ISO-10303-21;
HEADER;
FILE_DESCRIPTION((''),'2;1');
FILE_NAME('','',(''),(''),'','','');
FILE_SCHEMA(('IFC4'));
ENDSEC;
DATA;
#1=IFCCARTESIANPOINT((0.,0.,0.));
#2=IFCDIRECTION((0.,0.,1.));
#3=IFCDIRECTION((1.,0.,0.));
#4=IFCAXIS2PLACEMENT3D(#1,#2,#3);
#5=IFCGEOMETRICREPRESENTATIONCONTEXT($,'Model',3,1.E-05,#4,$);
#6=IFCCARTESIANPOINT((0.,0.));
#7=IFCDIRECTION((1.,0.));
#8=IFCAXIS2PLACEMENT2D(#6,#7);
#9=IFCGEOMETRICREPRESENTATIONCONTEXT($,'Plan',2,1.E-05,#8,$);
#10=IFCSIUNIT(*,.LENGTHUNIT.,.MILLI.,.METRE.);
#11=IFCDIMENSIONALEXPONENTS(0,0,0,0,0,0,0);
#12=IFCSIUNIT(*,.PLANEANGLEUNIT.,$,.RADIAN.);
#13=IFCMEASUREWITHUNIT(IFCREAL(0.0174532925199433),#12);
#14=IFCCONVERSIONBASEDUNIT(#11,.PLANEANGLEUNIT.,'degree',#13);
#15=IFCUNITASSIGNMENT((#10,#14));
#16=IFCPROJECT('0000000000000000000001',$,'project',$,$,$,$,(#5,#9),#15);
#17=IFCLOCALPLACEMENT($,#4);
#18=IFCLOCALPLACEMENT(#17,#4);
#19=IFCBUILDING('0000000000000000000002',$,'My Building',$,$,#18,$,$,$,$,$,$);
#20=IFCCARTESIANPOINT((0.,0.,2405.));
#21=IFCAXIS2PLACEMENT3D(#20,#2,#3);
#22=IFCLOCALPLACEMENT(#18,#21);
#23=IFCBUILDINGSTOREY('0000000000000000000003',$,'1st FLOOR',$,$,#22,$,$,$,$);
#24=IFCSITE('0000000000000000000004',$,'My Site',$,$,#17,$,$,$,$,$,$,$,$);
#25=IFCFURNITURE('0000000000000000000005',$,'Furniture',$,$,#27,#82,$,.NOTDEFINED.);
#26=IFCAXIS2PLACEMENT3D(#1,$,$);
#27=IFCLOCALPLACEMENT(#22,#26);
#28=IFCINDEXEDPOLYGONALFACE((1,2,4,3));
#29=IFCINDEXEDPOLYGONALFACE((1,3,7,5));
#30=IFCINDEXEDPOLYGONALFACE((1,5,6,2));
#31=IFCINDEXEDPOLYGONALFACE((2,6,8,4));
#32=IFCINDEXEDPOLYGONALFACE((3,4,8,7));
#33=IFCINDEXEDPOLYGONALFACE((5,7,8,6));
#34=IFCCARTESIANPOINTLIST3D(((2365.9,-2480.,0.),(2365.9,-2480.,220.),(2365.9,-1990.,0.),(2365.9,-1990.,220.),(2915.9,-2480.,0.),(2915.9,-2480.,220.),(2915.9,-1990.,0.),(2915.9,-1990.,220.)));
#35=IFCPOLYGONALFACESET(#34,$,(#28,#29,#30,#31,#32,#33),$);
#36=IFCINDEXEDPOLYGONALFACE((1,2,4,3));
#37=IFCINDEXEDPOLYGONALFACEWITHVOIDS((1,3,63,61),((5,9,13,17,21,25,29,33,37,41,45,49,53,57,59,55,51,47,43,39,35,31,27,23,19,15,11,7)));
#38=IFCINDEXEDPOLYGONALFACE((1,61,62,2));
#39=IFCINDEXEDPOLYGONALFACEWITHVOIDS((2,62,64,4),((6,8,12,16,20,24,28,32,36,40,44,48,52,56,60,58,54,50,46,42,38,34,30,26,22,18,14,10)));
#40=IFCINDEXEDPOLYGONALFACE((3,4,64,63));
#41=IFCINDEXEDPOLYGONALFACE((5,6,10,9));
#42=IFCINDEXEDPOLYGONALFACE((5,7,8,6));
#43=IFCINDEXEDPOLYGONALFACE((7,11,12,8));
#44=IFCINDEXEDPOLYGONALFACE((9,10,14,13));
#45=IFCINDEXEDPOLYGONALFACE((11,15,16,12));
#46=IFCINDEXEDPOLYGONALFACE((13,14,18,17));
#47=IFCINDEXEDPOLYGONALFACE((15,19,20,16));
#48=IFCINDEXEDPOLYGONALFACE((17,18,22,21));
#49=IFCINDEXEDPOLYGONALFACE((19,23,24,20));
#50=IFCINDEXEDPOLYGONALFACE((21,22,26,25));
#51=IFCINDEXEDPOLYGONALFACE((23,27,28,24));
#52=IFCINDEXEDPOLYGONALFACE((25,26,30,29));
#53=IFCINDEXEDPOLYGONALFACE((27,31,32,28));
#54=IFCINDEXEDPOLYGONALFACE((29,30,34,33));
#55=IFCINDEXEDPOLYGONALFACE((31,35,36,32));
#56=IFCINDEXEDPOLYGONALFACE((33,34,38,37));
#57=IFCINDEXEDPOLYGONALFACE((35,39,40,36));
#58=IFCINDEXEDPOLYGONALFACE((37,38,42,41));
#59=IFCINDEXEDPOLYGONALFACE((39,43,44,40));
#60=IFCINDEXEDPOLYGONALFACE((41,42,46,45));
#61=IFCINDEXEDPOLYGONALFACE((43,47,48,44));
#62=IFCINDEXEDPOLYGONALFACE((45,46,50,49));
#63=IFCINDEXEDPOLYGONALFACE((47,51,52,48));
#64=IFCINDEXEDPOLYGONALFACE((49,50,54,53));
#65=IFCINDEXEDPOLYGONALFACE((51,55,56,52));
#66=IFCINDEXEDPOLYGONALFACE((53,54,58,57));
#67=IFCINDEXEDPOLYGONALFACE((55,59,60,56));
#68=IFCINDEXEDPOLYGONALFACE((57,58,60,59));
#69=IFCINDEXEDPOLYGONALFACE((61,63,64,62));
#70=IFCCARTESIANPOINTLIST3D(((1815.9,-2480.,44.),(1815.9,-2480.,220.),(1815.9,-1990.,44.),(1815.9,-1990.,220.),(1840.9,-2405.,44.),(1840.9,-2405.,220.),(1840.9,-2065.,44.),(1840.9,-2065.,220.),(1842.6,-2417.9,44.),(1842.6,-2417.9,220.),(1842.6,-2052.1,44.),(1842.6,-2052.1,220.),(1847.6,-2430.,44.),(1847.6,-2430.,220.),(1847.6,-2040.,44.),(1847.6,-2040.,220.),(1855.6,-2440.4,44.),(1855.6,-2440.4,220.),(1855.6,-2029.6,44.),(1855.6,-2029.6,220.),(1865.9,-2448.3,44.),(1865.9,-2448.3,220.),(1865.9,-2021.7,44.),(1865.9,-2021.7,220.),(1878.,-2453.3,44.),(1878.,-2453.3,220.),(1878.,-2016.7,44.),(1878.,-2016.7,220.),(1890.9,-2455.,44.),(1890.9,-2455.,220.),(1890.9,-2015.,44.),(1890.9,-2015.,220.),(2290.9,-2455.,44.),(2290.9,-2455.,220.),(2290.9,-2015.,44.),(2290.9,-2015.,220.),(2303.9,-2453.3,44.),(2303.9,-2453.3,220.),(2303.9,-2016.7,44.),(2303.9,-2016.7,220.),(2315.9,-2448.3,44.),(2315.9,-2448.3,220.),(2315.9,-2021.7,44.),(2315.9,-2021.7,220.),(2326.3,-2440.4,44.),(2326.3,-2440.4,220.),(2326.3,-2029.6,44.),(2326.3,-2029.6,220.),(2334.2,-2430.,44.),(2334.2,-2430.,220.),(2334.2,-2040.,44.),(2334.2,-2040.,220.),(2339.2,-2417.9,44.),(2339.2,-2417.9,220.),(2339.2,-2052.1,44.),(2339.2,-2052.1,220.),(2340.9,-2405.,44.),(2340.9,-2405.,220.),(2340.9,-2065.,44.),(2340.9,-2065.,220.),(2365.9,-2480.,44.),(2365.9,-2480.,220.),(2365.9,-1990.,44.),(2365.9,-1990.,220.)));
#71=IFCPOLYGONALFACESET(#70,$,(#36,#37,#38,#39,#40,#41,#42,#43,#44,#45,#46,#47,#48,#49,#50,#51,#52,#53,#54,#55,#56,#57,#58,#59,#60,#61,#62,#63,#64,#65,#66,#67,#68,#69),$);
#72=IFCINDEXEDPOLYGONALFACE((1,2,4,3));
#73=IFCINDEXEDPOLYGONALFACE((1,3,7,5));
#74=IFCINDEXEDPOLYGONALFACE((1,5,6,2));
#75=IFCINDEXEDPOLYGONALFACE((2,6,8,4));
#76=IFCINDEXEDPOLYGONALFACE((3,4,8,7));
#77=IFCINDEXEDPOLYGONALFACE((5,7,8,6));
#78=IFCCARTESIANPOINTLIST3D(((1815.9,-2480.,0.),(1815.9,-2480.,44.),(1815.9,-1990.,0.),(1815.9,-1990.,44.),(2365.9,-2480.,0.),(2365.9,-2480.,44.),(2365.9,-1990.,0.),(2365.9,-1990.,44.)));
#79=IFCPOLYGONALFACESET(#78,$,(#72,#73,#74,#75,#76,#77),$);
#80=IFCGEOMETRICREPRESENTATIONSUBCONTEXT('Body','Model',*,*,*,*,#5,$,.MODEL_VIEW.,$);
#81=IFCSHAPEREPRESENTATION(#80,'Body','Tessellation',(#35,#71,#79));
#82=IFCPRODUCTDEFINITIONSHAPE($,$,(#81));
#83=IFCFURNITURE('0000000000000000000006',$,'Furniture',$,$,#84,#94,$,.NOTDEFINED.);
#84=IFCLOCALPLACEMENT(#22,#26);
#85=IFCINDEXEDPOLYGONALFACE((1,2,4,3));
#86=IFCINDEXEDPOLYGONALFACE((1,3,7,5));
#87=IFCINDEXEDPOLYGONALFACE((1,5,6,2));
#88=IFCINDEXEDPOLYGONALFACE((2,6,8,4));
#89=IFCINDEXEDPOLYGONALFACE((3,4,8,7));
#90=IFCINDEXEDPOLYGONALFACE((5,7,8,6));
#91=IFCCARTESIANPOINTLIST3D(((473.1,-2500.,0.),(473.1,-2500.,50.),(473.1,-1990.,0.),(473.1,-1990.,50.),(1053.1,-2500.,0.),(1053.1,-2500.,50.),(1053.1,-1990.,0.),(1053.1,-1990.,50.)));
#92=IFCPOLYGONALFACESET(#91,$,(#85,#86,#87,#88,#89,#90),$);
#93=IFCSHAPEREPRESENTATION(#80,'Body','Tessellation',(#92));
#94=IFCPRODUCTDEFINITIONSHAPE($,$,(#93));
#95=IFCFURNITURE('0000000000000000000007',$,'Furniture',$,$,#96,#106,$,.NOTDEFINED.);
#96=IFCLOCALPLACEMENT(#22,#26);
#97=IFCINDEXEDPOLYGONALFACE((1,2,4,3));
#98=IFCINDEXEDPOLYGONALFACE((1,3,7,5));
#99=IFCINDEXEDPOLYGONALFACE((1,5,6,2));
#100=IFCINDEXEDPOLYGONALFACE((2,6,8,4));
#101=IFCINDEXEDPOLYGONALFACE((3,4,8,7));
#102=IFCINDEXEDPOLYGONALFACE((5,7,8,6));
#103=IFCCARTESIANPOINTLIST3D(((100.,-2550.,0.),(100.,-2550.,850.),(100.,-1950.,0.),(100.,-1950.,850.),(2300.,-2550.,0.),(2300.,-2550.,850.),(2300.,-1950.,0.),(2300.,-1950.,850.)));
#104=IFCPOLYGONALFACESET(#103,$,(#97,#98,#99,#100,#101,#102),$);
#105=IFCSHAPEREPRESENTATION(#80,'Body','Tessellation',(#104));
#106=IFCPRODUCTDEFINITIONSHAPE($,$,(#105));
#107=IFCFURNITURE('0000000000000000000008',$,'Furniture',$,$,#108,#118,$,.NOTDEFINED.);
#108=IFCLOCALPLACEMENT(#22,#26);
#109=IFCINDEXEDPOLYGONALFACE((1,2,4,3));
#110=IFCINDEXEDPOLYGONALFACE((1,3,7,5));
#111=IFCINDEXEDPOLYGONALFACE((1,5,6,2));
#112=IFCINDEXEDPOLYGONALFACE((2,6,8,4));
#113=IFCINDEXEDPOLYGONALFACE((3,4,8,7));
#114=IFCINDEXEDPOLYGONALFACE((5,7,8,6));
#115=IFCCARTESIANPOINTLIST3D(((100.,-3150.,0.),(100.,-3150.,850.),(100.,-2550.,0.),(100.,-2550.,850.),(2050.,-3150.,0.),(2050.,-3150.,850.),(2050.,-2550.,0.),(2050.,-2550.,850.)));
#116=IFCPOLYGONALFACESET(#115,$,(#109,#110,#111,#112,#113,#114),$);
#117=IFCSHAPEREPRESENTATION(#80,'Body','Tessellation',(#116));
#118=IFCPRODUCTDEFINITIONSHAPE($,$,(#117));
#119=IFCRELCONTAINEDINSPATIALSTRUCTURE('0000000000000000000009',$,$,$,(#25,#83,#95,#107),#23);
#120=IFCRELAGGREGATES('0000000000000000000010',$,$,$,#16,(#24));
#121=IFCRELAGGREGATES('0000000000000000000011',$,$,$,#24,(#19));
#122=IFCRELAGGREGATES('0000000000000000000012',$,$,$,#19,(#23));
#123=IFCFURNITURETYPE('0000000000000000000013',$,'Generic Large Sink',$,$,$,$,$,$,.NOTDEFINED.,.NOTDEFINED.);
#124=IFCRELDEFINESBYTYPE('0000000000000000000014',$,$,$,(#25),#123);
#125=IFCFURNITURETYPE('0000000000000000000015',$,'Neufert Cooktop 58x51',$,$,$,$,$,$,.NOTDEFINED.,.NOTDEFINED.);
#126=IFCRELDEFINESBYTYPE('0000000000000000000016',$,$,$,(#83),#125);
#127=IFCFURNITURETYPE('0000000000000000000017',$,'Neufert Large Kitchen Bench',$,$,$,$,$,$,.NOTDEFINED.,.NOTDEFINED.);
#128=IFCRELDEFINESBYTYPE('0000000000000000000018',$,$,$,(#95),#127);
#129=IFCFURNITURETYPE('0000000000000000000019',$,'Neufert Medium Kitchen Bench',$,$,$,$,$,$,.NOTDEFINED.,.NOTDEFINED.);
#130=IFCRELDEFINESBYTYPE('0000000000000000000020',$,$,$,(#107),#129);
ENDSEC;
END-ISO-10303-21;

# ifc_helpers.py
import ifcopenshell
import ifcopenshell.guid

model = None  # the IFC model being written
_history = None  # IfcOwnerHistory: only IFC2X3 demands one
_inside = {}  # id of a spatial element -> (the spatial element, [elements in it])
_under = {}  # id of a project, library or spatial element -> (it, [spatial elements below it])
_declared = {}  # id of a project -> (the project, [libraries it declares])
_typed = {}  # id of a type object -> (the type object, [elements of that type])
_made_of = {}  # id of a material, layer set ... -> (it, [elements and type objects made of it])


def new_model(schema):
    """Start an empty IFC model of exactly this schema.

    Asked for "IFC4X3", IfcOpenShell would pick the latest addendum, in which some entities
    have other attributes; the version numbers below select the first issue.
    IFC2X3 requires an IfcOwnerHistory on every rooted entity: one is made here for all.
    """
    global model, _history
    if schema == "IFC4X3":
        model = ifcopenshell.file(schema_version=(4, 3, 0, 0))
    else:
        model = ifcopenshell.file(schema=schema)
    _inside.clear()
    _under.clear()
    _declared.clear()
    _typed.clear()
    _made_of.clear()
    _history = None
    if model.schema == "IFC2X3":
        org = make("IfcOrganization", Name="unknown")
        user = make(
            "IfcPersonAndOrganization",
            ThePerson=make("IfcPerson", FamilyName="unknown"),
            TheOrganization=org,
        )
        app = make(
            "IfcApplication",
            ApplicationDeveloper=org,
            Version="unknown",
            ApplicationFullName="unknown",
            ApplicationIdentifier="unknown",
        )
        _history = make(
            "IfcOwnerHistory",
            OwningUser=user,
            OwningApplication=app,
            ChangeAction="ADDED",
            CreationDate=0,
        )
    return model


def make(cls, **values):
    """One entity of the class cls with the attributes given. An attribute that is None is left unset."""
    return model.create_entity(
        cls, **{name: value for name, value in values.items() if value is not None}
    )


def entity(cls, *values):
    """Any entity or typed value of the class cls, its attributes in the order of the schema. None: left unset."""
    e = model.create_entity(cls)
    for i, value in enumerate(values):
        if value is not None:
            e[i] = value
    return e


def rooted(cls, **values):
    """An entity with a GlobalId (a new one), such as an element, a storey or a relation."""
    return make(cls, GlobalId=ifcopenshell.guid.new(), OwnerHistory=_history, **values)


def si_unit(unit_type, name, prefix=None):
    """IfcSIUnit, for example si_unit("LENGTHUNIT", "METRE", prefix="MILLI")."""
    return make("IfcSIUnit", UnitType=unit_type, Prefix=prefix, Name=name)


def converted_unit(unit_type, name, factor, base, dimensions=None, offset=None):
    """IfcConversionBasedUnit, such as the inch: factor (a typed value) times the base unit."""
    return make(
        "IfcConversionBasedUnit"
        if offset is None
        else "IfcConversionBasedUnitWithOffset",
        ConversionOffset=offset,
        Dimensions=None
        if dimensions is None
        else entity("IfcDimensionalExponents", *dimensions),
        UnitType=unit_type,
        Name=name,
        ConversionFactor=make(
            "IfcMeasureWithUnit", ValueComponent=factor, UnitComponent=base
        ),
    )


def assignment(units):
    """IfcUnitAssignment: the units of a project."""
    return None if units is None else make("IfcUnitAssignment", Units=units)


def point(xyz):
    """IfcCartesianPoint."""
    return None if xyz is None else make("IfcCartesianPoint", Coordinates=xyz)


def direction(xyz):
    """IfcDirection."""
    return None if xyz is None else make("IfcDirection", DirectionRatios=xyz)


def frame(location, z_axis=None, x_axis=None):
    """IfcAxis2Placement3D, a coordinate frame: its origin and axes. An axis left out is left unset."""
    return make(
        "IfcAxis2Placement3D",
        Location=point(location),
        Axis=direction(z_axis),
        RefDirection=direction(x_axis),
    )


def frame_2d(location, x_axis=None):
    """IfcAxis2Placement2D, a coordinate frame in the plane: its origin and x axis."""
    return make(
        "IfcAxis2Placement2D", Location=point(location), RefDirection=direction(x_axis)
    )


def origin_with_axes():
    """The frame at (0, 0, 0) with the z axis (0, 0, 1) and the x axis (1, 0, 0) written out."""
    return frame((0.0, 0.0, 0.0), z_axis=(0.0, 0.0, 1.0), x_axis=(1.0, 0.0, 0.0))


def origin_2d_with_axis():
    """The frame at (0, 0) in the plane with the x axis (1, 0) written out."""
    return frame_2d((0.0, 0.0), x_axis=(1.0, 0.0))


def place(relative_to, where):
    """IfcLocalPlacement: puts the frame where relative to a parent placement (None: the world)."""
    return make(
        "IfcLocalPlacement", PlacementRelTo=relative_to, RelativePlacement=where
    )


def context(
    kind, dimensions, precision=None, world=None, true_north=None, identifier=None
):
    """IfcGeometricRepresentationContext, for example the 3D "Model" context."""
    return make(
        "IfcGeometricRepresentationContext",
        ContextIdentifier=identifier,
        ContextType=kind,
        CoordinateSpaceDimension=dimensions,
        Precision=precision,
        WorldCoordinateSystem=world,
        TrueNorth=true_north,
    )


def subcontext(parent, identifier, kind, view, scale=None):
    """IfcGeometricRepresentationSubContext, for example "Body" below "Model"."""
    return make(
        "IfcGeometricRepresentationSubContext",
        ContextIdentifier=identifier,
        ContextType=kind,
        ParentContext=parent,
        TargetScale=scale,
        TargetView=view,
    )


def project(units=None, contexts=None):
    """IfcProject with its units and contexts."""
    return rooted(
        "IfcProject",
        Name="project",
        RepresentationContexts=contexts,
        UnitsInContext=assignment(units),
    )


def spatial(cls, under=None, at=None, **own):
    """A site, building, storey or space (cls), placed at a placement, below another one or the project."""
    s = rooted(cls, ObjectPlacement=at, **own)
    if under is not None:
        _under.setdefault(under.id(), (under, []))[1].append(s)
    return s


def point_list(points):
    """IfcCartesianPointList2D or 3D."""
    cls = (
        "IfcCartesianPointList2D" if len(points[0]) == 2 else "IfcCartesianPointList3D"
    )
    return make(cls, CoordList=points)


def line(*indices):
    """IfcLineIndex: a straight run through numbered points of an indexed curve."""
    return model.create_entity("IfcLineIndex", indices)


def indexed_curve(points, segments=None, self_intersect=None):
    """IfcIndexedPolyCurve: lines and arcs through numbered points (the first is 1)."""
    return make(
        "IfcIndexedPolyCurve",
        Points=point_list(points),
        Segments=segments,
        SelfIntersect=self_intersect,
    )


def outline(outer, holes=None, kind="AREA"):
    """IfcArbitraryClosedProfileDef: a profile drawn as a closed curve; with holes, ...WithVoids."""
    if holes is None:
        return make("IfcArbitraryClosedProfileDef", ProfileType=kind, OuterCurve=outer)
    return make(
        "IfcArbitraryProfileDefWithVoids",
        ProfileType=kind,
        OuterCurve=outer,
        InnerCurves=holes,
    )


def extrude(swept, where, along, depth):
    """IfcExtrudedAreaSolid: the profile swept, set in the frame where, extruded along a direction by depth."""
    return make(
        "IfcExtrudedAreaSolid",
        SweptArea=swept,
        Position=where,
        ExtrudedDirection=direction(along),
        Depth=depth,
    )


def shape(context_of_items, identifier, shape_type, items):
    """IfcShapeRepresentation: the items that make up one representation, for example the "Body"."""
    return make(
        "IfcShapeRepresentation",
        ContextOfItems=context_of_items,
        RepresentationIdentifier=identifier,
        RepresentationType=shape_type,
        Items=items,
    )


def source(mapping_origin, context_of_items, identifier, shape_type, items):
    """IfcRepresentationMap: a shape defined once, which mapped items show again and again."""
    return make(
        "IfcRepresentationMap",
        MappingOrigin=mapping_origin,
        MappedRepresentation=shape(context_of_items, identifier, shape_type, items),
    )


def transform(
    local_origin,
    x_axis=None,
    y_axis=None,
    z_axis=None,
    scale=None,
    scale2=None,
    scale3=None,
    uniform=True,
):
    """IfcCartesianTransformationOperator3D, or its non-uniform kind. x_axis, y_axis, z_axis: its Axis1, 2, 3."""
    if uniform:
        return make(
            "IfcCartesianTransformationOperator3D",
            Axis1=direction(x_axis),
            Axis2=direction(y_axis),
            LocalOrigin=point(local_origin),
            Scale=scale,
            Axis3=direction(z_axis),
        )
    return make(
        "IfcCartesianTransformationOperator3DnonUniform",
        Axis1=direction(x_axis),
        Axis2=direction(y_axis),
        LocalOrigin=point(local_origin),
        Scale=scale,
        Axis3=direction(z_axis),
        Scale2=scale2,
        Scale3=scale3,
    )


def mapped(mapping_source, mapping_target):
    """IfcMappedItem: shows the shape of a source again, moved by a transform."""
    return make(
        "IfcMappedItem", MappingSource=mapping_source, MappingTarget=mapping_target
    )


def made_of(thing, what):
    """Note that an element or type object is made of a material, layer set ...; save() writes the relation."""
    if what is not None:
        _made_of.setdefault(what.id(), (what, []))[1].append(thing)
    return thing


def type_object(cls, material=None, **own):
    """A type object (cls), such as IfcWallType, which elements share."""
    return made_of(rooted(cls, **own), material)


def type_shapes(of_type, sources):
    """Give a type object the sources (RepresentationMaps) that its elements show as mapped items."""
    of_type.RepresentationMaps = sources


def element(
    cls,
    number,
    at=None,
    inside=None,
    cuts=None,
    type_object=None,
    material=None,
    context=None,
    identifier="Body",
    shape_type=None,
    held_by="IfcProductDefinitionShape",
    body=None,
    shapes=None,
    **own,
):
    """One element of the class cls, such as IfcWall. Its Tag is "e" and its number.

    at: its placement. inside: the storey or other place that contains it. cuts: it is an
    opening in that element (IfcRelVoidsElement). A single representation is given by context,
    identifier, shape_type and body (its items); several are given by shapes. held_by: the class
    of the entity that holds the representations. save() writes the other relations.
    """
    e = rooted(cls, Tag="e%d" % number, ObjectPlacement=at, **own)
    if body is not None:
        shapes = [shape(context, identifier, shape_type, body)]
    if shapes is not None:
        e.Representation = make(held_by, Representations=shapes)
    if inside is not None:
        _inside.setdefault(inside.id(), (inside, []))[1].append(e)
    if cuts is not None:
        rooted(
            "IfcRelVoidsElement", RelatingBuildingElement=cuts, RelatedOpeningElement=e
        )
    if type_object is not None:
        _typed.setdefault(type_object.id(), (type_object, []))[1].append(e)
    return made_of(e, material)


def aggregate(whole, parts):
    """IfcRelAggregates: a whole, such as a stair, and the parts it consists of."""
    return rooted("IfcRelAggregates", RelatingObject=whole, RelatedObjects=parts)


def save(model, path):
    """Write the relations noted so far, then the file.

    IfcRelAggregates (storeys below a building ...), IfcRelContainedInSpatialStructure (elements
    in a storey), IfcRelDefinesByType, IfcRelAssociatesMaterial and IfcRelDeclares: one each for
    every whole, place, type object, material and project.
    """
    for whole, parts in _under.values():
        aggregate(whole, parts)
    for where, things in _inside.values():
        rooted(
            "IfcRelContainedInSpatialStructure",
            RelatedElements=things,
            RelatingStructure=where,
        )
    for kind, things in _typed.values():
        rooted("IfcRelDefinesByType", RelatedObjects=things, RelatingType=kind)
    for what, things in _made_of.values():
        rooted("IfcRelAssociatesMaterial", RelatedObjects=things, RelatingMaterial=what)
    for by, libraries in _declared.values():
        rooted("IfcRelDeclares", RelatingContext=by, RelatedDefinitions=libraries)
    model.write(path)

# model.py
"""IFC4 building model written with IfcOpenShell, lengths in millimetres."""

from ifc_helpers import new_model, entity, si_unit, converted_unit, frame, origin_with_axes, origin_2d_with_axis, place, context, subcontext, project, spatial, line, indexed_curve, outline, extrude, source, transform, mapped, type_object, type_shapes, element, save


model = new_model("IFC4")

# Units and contexts
model_context = context("Model", 3, precision=1e-05, world=origin_with_axes())
plan_context = context("Plan", 2, precision=1e-05, world=origin_2d_with_axis())
body_context = subcontext(model_context, "Body", "Model", "MODEL_VIEW")
ifc_project = project(units=[si_unit("LENGTHUNIT", "METRE", prefix="MILLI"), converted_unit("PLANEANGLEUNIT", "degree", entity("IfcReal", 0.0174532925199433), si_unit("PLANEANGLEUNIT", "RADIAN"), dimensions=[0, 0, 0, 0, 0, 0, 0])], contexts=[model_context, plan_context])

# Site, building, storey
site_placement = place(None, origin_with_axes())
site = spatial("IfcSite", under=ifc_project, at=site_placement, Name="My Site")
building_placement = place(site_placement, origin_with_axes())
building = spatial("IfcBuilding", under=site, at=building_placement, Name="My Building")
storey_placement = place(building_placement, frame((0.0, 0.0, 2405.0), z_axis=(0.0, 0.0, 1.0), x_axis=(1.0, 0.0, 0.0)))
storey = spatial("IfcBuildingStorey", under=building, at=storey_placement, Name="1st FLOOR")

# Furniture
furniture_type_1 = type_object("IfcFurnitureType", Name="Generic Large Sink", AssemblyPlace="NOTDEFINED", PredefinedType="NOTDEFINED")
shared_indexed_poly_curve = entity("IfcIndexedPolyCurve", entity("IfcCartesianPointList2D", [[550.0, 0.0], [550.0, 490.0], [1100.0, 490.0], [1100.0, 0.0]]), [entity("IfcLineIndex", [1, 2]), entity("IfcLineIndex", [2, 3]), entity("IfcLineIndex", [3, 4]), entity("IfcLineIndex", [4, 1])])
shared_shape_1 = source(origin_with_axes(), body_context, "Body", "SweptSolid", [
    extrude(outline(indexed_curve([(0.0, 0.0), (0.0, 490.0), (550.0, 490.0), (550.0, 0.0)], segments=[line(1, 2), line(2, 3), line(3, 4), line(4, 1)])), frame((-550.0, -490.0, 0.0), z_axis=(0.0, 0.0, 1.0), x_axis=(1.0, 0.0, 0.0)), (0.0, 0.0, 1.0), 220.0),
    entity("IfcExtrudedAreaSolid", entity("IfcArbitraryProfileDefWithVoids", "AREA", None, shared_indexed_poly_curve, [entity("IfcIndexedPolyCurve", entity("IfcCartesianPointList2D", [[625.0, 25.0], [589.6, 39.6], [575.0, 75.0], [575.0, 415.0], [589.6, 450.4], [625.0, 465.0], [1025.0, 465.0], [1060.4, 450.4], [1075.0, 415.0], [1075.0, 75.0], [1060.4, 39.6], [1025.0, 25.0]]), [entity("IfcLineIndex", [12, 1]), entity("IfcArcIndex", [1, 2, 3]), entity("IfcLineIndex", [3, 4]), entity("IfcArcIndex", [4, 5, 6]), entity("IfcLineIndex", [6, 7]), entity("IfcArcIndex", [7, 8, 9]), entity("IfcLineIndex", [9, 10]), entity("IfcArcIndex", [10, 11, 12]), entity("IfcLineIndex", [1, 12])])]), entity("IfcAxis2Placement3D", entity("IfcCartesianPoint", [-550.0, -490.0, 44.0]), entity("IfcDirection", [0.0, 0.0, 1.0]), entity("IfcDirection", [1.0, 0.0, 0.0])), entity("IfcDirection", [0.0, 0.0, 1.0]), 176.0),
    entity("IfcExtrudedAreaSolid", entity("IfcArbitraryClosedProfileDef", "AREA", None, shared_indexed_poly_curve), entity("IfcAxis2Placement3D", entity("IfcCartesianPoint", [-550.0, -490.0, 0.0]), entity("IfcDirection", [0.0, 0.0, 1.0]), entity("IfcDirection", [1.0, 0.0, 0.0])), entity("IfcDirection", [0.0, 0.0, 1.0]), 44.0),
])
type_shapes(furniture_type_1, [shared_shape_1])
furniture_1_placement = place(storey_placement, frame((2365.9, -2480.0, 0.0), z_axis=(0.0, 0.0, 1.0), x_axis=(-1.0, 0.0, 0.0)))
element("IfcFurniture", 1, at=furniture_1_placement, inside=storey, type_object=furniture_type_1, Name="Furniture", PredefinedType="NOTDEFINED", context=body_context, shape_type="MappedRepresentation", body=[
    mapped(shared_shape_1, transform((0.0, 0.0, 0.0), x_axis=(1.0, 0.0, 0.0), y_axis=(0.0, 1.0, 0.0), z_axis=(0.0, 0.0, 1.0), scale=1.0)),
])
furniture_type_2 = type_object("IfcFurnitureType", Name="Neufert Cooktop 58x51", AssemblyPlace="NOTDEFINED", PredefinedType="NOTDEFINED")
shared_shape_2 = source(origin_with_axes(), body_context, "Body", "SweptSolid", [
    extrude(outline(indexed_curve([(0.0, 0.0), (0.0, 510.0), (580.0, 510.0), (580.0, 0.0)], segments=[line(1, 2), line(2, 3), line(3, 4), line(4, 1)])), origin_with_axes(), (0.0, 0.0, 1.0), 50.0),
])
type_shapes(furniture_type_2, [shared_shape_2])
furniture_2_placement = place(storey_placement, frame((473.1, -2500.0, 0.0), z_axis=(0.0, 0.0, 1.0), x_axis=(1.0, 0.0, 0.0)))
element("IfcFurniture", 2, at=furniture_2_placement, inside=storey, type_object=furniture_type_2, Name="Furniture", PredefinedType="NOTDEFINED", context=body_context, shape_type="MappedRepresentation", body=[
    mapped(shared_shape_2, transform((0.0, 0.0, 0.0), x_axis=(1.0, 0.0, 0.0), y_axis=(0.0, 1.0, 0.0), z_axis=(0.0, 0.0, 1.0), scale=1.0)),
])
furniture_type_3 = type_object("IfcFurnitureType", Name="Neufert Large Kitchen Bench", AssemblyPlace="NOTDEFINED", PredefinedType="NOTDEFINED")
shared_shape_3 = source(origin_with_axes(), body_context, "Body", "SweptSolid", [
    extrude(outline(indexed_curve([(0.0, 0.0), (0.0, 600.0), (2200.0, 600.0), (2200.0, 0.0)], segments=[line(1, 2), line(2, 3), line(3, 4), line(4, 1)])), origin_with_axes(), (0.0, 0.0, 1.0), 850.0),
])
type_shapes(furniture_type_3, [shared_shape_3])
furniture_3_placement = place(storey_placement, frame((100.0, -2550.0, 0.0), z_axis=(0.0, 0.0, 1.0), x_axis=(1.0, 0.0, 0.0)))
element("IfcFurniture", 3, at=furniture_3_placement, inside=storey, type_object=furniture_type_3, Name="Furniture", PredefinedType="NOTDEFINED", context=body_context, shape_type="MappedRepresentation", body=[
    mapped(shared_shape_3, transform((0.0, 0.0, 0.0), x_axis=(1.0, 0.0, 0.0), y_axis=(0.0, 1.0, 0.0), z_axis=(0.0, 0.0, 1.0), scale=1.0)),
])
furniture_type_4 = type_object("IfcFurnitureType", Name="Neufert Medium Kitchen Bench", AssemblyPlace="NOTDEFINED", PredefinedType="NOTDEFINED")
shared_shape_4 = source(origin_with_axes(), body_context, "Body", "SweptSolid", [
    extrude(outline(indexed_curve([(0.0, 0.0), (0.0, 600.0), (1950.0, 600.0), (1950.0, 0.0)], segments=[line(1, 2), line(2, 3), line(3, 4), line(4, 1)])), origin_with_axes(), (0.0, 0.0, 1.0), 850.0),
])
type_shapes(furniture_type_4, [shared_shape_4])
furniture_4_placement = place(storey_placement, frame((100.0, -3150.0, 0.0), z_axis=(0.0, 0.0, 1.0), x_axis=(1.0, 0.0, 0.0)))
element("IfcFurniture", 4, at=furniture_4_placement, inside=storey, type_object=furniture_type_4, Name="Furniture", PredefinedType="NOTDEFINED", context=body_context, shape_type="MappedRepresentation", body=[
    mapped(shared_shape_4, transform((0.0, 0.0, 0.0), x_axis=(1.0, 0.0, 0.0), y_axis=(0.0, 1.0, 0.0), z_axis=(0.0, 0.0, 1.0), scale=1.0)),
])

save(model, "model.ifc")
